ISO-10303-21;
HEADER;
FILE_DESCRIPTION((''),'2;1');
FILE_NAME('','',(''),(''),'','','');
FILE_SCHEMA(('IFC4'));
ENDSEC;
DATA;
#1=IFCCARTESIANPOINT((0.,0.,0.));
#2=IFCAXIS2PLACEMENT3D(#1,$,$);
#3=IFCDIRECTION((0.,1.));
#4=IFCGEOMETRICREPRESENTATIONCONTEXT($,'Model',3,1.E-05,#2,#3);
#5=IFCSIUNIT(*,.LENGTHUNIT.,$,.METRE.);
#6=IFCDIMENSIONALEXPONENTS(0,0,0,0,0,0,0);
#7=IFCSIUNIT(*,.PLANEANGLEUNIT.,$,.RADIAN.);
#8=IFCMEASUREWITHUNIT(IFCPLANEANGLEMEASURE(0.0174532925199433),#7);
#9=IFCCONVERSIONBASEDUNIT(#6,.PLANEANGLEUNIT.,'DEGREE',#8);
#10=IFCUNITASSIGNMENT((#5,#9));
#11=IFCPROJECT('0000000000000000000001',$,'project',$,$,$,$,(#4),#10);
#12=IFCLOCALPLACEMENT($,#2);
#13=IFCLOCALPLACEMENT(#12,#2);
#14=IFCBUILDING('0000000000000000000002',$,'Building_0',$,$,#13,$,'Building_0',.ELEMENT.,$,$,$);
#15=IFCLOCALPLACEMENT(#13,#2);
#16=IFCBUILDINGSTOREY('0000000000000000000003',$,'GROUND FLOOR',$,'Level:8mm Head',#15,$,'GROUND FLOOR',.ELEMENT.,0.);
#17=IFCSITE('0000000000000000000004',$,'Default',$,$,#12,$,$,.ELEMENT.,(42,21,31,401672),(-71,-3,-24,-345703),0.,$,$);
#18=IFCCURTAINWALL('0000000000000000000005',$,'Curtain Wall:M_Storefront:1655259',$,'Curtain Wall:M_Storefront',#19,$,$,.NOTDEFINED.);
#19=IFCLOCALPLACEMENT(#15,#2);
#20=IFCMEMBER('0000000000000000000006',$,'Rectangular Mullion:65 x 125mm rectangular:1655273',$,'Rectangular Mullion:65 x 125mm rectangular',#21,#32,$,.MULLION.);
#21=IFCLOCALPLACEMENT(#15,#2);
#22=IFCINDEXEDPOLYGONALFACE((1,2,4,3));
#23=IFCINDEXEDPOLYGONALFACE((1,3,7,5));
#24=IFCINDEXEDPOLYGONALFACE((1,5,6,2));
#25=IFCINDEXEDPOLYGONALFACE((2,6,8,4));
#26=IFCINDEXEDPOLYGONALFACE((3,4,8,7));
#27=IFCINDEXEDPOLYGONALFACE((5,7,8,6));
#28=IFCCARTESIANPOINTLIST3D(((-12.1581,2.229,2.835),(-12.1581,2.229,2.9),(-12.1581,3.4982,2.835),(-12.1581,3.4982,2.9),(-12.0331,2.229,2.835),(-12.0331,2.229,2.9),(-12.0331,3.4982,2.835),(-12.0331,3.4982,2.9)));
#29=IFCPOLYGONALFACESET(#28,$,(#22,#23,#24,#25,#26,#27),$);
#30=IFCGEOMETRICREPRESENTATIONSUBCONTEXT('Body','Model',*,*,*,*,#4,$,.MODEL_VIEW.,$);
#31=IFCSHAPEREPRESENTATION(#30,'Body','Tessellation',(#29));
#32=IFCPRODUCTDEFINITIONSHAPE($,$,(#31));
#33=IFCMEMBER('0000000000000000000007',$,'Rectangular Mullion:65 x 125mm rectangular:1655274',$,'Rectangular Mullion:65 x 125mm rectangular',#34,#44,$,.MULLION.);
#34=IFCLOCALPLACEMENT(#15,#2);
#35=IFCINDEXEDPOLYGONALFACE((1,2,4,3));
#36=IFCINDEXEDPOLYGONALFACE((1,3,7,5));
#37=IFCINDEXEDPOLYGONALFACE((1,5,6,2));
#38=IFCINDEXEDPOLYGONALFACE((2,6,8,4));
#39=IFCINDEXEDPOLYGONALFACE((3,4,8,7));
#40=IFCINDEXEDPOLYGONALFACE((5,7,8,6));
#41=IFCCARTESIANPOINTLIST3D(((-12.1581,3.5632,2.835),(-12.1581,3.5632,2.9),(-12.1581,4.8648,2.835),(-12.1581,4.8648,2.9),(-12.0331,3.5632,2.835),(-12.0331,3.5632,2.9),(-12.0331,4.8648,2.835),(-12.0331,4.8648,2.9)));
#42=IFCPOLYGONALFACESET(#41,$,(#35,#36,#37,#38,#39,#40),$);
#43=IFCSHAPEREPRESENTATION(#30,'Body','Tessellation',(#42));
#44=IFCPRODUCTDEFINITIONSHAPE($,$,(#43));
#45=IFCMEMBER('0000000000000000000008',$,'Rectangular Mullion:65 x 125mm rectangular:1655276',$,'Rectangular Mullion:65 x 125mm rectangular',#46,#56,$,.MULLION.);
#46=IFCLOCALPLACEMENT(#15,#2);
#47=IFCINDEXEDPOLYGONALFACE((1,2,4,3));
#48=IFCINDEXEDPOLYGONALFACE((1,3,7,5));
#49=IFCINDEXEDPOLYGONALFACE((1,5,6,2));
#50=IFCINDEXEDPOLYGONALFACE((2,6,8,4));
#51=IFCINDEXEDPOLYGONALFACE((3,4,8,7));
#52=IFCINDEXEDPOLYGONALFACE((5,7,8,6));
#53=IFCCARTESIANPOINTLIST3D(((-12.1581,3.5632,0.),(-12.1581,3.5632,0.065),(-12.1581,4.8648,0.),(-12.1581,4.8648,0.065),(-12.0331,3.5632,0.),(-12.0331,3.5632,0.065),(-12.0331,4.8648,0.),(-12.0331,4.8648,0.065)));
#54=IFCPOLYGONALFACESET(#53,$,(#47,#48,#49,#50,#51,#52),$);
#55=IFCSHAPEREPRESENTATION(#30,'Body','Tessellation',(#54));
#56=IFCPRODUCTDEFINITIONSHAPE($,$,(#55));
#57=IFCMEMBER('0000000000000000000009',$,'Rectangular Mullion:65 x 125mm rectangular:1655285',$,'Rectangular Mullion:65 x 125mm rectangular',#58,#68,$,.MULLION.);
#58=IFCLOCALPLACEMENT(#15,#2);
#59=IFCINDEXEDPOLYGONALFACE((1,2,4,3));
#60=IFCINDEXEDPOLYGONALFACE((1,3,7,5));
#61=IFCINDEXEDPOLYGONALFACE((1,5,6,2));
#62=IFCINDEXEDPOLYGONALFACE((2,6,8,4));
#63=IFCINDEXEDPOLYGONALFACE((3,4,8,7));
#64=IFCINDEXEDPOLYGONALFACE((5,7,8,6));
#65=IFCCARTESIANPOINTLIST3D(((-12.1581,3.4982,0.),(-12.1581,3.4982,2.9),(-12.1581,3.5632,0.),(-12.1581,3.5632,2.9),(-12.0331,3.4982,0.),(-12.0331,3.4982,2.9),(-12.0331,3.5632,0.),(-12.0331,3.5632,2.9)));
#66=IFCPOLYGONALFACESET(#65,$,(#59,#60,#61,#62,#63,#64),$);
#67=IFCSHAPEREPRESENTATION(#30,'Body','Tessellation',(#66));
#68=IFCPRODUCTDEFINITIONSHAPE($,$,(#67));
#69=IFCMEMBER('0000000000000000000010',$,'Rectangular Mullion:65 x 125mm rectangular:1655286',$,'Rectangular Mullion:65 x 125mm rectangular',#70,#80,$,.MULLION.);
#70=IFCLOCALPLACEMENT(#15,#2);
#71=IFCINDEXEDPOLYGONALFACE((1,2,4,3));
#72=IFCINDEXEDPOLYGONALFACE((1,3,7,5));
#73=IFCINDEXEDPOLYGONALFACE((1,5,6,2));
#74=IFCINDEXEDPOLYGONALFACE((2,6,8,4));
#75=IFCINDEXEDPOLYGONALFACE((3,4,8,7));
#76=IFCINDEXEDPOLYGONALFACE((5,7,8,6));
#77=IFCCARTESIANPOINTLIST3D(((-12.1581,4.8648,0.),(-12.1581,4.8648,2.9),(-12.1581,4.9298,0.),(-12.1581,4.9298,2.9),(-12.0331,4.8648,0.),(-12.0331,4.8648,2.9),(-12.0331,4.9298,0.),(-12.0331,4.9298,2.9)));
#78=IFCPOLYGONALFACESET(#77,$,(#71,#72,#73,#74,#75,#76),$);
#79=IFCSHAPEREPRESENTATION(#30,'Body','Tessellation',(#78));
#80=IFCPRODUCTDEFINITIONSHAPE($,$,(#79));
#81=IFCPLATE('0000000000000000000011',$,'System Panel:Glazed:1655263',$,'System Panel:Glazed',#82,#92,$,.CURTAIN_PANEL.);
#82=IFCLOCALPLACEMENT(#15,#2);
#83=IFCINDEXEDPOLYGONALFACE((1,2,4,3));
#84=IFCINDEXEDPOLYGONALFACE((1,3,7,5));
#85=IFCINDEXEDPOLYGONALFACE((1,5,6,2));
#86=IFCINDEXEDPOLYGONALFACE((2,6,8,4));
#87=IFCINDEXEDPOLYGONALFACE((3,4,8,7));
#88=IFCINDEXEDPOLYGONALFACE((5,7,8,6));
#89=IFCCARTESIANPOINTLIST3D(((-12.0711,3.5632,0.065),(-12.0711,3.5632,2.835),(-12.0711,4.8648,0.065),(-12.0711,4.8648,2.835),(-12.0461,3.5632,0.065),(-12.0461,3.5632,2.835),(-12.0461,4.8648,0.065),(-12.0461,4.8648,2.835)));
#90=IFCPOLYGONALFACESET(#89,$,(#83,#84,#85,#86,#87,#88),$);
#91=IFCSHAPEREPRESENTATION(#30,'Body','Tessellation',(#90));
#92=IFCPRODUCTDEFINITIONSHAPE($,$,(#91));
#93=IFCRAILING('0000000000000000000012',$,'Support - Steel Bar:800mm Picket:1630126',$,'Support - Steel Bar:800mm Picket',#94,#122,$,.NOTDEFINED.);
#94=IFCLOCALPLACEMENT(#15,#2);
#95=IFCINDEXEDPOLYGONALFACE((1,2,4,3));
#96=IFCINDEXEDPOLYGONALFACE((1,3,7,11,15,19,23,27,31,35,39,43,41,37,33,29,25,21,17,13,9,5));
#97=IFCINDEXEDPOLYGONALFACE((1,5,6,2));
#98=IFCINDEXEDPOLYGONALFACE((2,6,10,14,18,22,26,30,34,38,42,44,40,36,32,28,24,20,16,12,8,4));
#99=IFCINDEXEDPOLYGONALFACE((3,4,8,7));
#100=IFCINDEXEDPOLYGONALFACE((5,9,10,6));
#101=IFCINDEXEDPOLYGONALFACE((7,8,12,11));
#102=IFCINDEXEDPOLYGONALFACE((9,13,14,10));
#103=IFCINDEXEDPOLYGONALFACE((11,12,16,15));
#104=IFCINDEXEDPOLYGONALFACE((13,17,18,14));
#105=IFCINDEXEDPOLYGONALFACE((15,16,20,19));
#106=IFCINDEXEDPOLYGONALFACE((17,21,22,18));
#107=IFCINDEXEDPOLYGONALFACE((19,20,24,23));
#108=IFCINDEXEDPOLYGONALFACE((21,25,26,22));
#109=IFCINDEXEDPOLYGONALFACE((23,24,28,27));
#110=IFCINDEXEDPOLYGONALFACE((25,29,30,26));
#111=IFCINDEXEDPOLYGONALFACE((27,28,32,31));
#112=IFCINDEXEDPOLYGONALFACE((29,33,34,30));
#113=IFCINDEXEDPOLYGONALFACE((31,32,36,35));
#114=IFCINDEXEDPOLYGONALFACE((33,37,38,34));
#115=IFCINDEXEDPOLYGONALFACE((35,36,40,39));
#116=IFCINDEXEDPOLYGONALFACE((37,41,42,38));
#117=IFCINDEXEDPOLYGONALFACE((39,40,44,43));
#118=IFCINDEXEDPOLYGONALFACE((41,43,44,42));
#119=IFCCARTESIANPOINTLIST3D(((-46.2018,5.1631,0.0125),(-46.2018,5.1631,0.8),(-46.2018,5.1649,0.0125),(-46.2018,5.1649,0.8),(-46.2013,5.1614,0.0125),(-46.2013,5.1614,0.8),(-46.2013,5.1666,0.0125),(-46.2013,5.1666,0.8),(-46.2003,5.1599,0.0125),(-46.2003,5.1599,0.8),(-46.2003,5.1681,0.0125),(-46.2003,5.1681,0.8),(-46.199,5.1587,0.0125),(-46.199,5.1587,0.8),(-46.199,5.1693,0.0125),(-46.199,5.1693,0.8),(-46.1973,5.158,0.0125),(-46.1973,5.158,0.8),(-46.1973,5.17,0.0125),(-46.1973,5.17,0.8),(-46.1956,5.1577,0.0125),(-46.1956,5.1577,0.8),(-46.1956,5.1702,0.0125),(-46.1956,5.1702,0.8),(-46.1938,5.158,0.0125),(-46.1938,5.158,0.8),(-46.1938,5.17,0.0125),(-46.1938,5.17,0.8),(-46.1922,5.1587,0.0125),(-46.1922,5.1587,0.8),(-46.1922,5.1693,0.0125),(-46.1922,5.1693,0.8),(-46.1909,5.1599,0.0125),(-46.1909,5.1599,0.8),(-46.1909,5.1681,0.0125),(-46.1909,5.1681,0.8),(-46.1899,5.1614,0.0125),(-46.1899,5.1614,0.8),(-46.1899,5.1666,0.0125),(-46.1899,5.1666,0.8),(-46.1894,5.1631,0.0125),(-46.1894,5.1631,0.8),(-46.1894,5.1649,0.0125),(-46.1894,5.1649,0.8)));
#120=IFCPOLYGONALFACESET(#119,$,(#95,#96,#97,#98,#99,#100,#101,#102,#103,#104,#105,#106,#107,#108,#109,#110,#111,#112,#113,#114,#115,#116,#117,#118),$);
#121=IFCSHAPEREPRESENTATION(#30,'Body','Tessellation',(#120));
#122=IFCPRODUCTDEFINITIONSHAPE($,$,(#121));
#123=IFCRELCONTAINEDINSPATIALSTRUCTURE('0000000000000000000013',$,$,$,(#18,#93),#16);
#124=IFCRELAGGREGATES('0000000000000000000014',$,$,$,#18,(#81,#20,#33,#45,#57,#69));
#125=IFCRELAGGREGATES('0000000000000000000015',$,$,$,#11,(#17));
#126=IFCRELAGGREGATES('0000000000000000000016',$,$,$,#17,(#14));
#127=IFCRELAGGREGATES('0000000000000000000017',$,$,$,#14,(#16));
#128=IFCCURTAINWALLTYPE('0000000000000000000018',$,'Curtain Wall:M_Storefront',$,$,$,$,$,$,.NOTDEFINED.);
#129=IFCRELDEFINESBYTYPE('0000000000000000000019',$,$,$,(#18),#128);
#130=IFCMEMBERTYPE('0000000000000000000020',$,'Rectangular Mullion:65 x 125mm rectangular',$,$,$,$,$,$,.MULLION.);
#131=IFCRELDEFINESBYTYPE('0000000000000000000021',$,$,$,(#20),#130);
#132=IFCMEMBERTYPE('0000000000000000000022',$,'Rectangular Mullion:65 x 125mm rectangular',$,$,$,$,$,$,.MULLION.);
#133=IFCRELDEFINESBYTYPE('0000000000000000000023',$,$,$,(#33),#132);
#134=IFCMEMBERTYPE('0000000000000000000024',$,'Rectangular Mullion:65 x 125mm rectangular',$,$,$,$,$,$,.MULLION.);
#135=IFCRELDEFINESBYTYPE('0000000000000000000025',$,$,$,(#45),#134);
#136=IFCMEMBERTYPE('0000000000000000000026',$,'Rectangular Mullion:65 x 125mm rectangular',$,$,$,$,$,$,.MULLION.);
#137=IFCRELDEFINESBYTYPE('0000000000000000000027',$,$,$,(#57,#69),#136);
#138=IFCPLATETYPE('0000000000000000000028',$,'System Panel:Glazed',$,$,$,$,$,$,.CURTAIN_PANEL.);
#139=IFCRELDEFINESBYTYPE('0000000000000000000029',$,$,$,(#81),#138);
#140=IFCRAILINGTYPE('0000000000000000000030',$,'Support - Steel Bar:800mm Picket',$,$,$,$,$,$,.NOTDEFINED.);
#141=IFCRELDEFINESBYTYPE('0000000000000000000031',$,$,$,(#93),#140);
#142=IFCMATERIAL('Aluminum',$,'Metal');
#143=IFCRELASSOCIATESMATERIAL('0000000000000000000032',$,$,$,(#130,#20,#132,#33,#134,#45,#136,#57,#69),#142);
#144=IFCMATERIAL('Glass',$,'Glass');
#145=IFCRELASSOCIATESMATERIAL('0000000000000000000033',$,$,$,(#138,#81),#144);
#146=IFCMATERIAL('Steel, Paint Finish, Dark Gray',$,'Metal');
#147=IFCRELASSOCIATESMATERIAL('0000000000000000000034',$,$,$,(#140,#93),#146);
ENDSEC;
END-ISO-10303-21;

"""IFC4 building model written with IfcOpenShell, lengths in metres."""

from ifc_helpers import new_model, entity, si_unit, converted_unit, direction, frame, origin, place, context, subcontext, project, spatial, arc, indexed_curve, outline, extrude, source, transform, mapped, material, type_object, type_shapes, element, aggregate, save


model = new_model("IFC4")

# Units and contexts
model_context = context("Model", 3, precision=1e-05, world=origin(), true_north=direction((0.0, 1.0)))
body_context = subcontext(model_context, "Body", "Model", "MODEL_VIEW")
ifc_project = project(units=[si_unit("LENGTHUNIT", "METRE"), converted_unit("PLANEANGLEUNIT", "DEGREE", entity("IfcPlaneAngleMeasure", 0.0174532925199433), si_unit("PLANEANGLEUNIT", "RADIAN"), dimensions=[0, 0, 0, 0, 0, 0, 0])], contexts=[model_context])

# Site, building, storey
site_placement = place(None, origin())
site = spatial("IfcSite", under=ifc_project, at=site_placement, Name="Default", CompositionType="ELEMENT", RefLatitude=(42, 21, 31, 401672), RefLongitude=(-71, -3, -24, -345703), RefElevation=0.0)
building_placement = place(site_placement, origin())
building = spatial("IfcBuilding", under=site, at=building_placement, Name="Building_0", LongName="Building_0", CompositionType="ELEMENT")
storey_placement = place(building_placement, origin())
storey = spatial("IfcBuildingStorey", under=building, at=storey_placement, Name="GROUND FLOOR", ObjectType="Level:8mm Head", LongName="GROUND FLOOR", CompositionType="ELEMENT", Elevation=0.0)

# Curtain wall, members, plate
curtain_wall_type = type_object("IfcCurtainWallType", Name="Curtain Wall:M_Storefront", PredefinedType="NOTDEFINED")
curtain_wall_placement = place(storey_placement, origin())
curtain_wall = element("IfcCurtainWall", 1, at=curtain_wall_placement, inside=storey, type_object=curtain_wall_type, Name="Curtain Wall:M_Storefront:1655259", ObjectType="Curtain Wall:M_Storefront", PredefinedType="NOTDEFINED")
ifc_material_1 = material(Name="Aluminum", Category="Metal")
member_type_1 = type_object("IfcMemberType", Name="Rectangular Mullion:65 x 125mm rectangular", PredefinedType="MULLION", material=ifc_material_1)
shared_shape_1 = source(origin(), body_context, "Body", "SweptSolid", [
    extrude(outline(indexed_curve([(-0.0325, -0.0625), (0.0325, -0.0625), (0.0325, 0.0625), (-0.0325, 0.0625), (-0.0325, -0.0625)], self_intersect=False)), frame((-0.0325, 0.0, -1.2692), z_axis=(0.0, 0.0, 1.0), x_axis=(-1.0, 0.0, 0.0)), (0.0, 0.0, 1.0), 1.2692),
])
type_shapes(member_type_1, [shared_shape_1])
member_1_placement = place(curtain_wall_placement, frame((-12.0956, 3.4982, 2.9), z_axis=(0.0, 1.0, 0.0), x_axis=(0.0, 0.0, 1.0)))
member_1 = element("IfcMember", 2, at=member_1_placement, type_object=member_type_1, material=ifc_material_1, Name="Rectangular Mullion:65 x 125mm rectangular:1655273", ObjectType="Rectangular Mullion:65 x 125mm rectangular", PredefinedType="MULLION", context=body_context, shape_type="MappedRepresentation", body=[
    mapped(shared_shape_1, transform((0.0, 0.0, 0.0), scale=1.0)),
])
member_type_2 = type_object("IfcMemberType", Name="Rectangular Mullion:65 x 125mm rectangular", PredefinedType="MULLION", material=ifc_material_1)
shared_shape_2 = source(origin(), body_context, "Body", "SweptSolid", [
    extrude(outline(indexed_curve([(-0.0325, -0.0625), (0.0325, -0.0625), (0.0325, 0.0625), (-0.0325, 0.0625), (-0.0325, -0.0625)], self_intersect=False)), frame((-0.0325, 0.0, -1.3017), z_axis=(0.0, 0.0, 1.0), x_axis=(-1.0, 0.0, 0.0)), (0.0, 0.0, 1.0), 1.3017),
])
type_shapes(member_type_2, [shared_shape_2])
member_2_placement = place(curtain_wall_placement, frame((-12.0956, 4.8648, 2.9), z_axis=(0.0, 1.0, 0.0), x_axis=(0.0, 0.0, 1.0)))
member_2 = element("IfcMember", 3, at=member_2_placement, type_object=member_type_2, material=ifc_material_1, Name="Rectangular Mullion:65 x 125mm rectangular:1655274", ObjectType="Rectangular Mullion:65 x 125mm rectangular", PredefinedType="MULLION", context=body_context, shape_type="MappedRepresentation", body=[
    mapped(shared_shape_2, transform((0.0, 0.0, 0.0), scale=1.0)),
])
member_type_3 = type_object("IfcMemberType", Name="Rectangular Mullion:65 x 125mm rectangular", PredefinedType="MULLION", material=ifc_material_1)
shared_shape_3 = source(origin(), body_context, "Body", "SweptSolid", [
    extrude(outline(indexed_curve([(-0.0325, -0.0625), (0.0325, -0.0625), (0.0325, 0.0625), (-0.0325, 0.0625), (-0.0325, -0.0625)], self_intersect=False)), frame((-0.0325, 0.0, -1.3017), z_axis=(0.0, 0.0, 1.0), x_axis=(-1.0, 0.0, 0.0)), (0.0, 0.0, 1.0), 1.3017),
])
type_shapes(member_type_3, [shared_shape_3])
member_3_placement = place(curtain_wall_placement, frame((-12.0956, 3.5632, 0.0), z_axis=(0.0, -1.0, 0.0), x_axis=(0.0, 0.0, -1.0)))
member_3 = element("IfcMember", 4, at=member_3_placement, type_object=member_type_3, material=ifc_material_1, Name="Rectangular Mullion:65 x 125mm rectangular:1655276", ObjectType="Rectangular Mullion:65 x 125mm rectangular", PredefinedType="MULLION", context=body_context, shape_type="MappedRepresentation", body=[
    mapped(shared_shape_3, transform((0.0, 0.0, 0.0), scale=1.0)),
])
member_type_4 = type_object("IfcMemberType", Name="Rectangular Mullion:65 x 125mm rectangular", PredefinedType="MULLION", material=ifc_material_1)
shared_shape_4 = source(origin(), body_context, "Body", "SweptSolid", [
    extrude(outline(indexed_curve([(-0.0325, -0.0625), (0.0325, -0.0625), (0.0325, 0.0625), (-0.0325, 0.0625), (-0.0325, -0.0625)], self_intersect=False)), frame((0.0, 0.0, -2.9), z_axis=(0.0, 0.0, 1.0), x_axis=(-1.0, 0.0, 0.0)), (0.0, 0.0, 1.0), 2.9),
])
type_shapes(member_type_4, [shared_shape_4])
member_4_placement = place(curtain_wall_placement, frame((-12.0956, 3.5307, 0.0), z_axis=(0.0, 0.0, -1.0), x_axis=(0.0, 1.0, 0.0)))
member_4 = element("IfcMember", 5, at=member_4_placement, type_object=member_type_4, material=ifc_material_1, Name="Rectangular Mullion:65 x 125mm rectangular:1655285", ObjectType="Rectangular Mullion:65 x 125mm rectangular", PredefinedType="MULLION", context=body_context, shape_type="MappedRepresentation", body=[
    mapped(shared_shape_4, transform((0.0, 0.0, 0.0), scale=1.0)),
])
member_5_placement = place(curtain_wall_placement, frame((-12.0956, 4.8973, 0.0), z_axis=(0.0, 0.0, -1.0), x_axis=(0.0, 1.0, 0.0)))
member_5 = element("IfcMember", 6, at=member_5_placement, type_object=member_type_4, material=ifc_material_1, Name="Rectangular Mullion:65 x 125mm rectangular:1655286", ObjectType="Rectangular Mullion:65 x 125mm rectangular", PredefinedType="MULLION", context=body_context, shape_type="MappedRepresentation", body=[
    mapped(shared_shape_4, transform((0.0, 0.0, 0.0), scale=1.0)),
])
ifc_material_2 = material(Name="Glass", Category="Glass")
plate_type = type_object("IfcPlateType", Name="System Panel:Glazed", PredefinedType="CURTAIN_PANEL", material=ifc_material_2)
shared_shape_5 = source(origin(), body_context, "Body", "SweptSolid", [
    extrude(outline(indexed_curve([(-0.0125, -0.6508), (0.0125, -0.6508), (0.0125, 0.6508), (-0.0125, 0.6508), (-0.0125, -0.6508)], self_intersect=False)), frame((0.0, -0.037, 0.0), z_axis=(0.0, 0.0, 1.0), x_axis=(0.0, 1.0, 0.0)), (0.0, 0.0, 1.0), 2.77),
])
type_shapes(plate_type, [shared_shape_5])
plate_placement = place(curtain_wall_placement, frame((-12.0956, 4.214, 0.065), z_axis=(0.0, 0.0, 1.0), x_axis=(0.0, 1.0, 0.0)))
plate = element("IfcPlate", 7, at=plate_placement, type_object=plate_type, material=ifc_material_2, Name="System Panel:Glazed:1655263", ObjectType="System Panel:Glazed", PredefinedType="CURTAIN_PANEL", context=body_context, shape_type="MappedRepresentation", body=[
    mapped(shared_shape_5, transform((0.0, 0.0, 0.0), scale=1.0)),
])
aggregate(curtain_wall, [plate, member_1, member_2, member_3, member_4, member_5])

# Railing
ifc_material_3 = material(Name="Steel, Paint Finish, Dark Gray", Category="Metal")
railing_type = type_object("IfcRailingType", Name="Support - Steel Bar:800mm Picket", PredefinedType="NOTDEFINED", material=ifc_material_3)
shared_shape_6 = source(origin(), body_context, "Body", "SweptSolid", [
    extrude(outline(indexed_curve([(-0.0063, 0.0), (0.0, -0.0063), (0.0063, 0.0), (0.0, 0.0062)], segments=[arc(1, 2, 3), arc(3, 4, 1)], self_intersect=False)), frame((0.0, 0.0, 0.0125), z_axis=(0.0, 0.0, 1.0), x_axis=(0.0, 1.0, 0.0)), (0.0, 0.0, 1.0), 0.7875),
])
type_shapes(railing_type, [shared_shape_6])
railing_placement = place(storey_placement, frame((-46.1956, 5.164, 0.0)))
element("IfcRailing", 8, at=railing_placement, inside=storey, type_object=railing_type, material=ifc_material_3, Name="Support - Steel Bar:800mm Picket:1630126", ObjectType="Support - Steel Bar:800mm Picket", PredefinedType="NOTDEFINED", context=body_context, shape_type="MappedRepresentation", body=[
    mapped(shared_shape_6, transform((0.0, 0.0, 0.0), scale=1.0)),
])

save(model, "model.ifc")
